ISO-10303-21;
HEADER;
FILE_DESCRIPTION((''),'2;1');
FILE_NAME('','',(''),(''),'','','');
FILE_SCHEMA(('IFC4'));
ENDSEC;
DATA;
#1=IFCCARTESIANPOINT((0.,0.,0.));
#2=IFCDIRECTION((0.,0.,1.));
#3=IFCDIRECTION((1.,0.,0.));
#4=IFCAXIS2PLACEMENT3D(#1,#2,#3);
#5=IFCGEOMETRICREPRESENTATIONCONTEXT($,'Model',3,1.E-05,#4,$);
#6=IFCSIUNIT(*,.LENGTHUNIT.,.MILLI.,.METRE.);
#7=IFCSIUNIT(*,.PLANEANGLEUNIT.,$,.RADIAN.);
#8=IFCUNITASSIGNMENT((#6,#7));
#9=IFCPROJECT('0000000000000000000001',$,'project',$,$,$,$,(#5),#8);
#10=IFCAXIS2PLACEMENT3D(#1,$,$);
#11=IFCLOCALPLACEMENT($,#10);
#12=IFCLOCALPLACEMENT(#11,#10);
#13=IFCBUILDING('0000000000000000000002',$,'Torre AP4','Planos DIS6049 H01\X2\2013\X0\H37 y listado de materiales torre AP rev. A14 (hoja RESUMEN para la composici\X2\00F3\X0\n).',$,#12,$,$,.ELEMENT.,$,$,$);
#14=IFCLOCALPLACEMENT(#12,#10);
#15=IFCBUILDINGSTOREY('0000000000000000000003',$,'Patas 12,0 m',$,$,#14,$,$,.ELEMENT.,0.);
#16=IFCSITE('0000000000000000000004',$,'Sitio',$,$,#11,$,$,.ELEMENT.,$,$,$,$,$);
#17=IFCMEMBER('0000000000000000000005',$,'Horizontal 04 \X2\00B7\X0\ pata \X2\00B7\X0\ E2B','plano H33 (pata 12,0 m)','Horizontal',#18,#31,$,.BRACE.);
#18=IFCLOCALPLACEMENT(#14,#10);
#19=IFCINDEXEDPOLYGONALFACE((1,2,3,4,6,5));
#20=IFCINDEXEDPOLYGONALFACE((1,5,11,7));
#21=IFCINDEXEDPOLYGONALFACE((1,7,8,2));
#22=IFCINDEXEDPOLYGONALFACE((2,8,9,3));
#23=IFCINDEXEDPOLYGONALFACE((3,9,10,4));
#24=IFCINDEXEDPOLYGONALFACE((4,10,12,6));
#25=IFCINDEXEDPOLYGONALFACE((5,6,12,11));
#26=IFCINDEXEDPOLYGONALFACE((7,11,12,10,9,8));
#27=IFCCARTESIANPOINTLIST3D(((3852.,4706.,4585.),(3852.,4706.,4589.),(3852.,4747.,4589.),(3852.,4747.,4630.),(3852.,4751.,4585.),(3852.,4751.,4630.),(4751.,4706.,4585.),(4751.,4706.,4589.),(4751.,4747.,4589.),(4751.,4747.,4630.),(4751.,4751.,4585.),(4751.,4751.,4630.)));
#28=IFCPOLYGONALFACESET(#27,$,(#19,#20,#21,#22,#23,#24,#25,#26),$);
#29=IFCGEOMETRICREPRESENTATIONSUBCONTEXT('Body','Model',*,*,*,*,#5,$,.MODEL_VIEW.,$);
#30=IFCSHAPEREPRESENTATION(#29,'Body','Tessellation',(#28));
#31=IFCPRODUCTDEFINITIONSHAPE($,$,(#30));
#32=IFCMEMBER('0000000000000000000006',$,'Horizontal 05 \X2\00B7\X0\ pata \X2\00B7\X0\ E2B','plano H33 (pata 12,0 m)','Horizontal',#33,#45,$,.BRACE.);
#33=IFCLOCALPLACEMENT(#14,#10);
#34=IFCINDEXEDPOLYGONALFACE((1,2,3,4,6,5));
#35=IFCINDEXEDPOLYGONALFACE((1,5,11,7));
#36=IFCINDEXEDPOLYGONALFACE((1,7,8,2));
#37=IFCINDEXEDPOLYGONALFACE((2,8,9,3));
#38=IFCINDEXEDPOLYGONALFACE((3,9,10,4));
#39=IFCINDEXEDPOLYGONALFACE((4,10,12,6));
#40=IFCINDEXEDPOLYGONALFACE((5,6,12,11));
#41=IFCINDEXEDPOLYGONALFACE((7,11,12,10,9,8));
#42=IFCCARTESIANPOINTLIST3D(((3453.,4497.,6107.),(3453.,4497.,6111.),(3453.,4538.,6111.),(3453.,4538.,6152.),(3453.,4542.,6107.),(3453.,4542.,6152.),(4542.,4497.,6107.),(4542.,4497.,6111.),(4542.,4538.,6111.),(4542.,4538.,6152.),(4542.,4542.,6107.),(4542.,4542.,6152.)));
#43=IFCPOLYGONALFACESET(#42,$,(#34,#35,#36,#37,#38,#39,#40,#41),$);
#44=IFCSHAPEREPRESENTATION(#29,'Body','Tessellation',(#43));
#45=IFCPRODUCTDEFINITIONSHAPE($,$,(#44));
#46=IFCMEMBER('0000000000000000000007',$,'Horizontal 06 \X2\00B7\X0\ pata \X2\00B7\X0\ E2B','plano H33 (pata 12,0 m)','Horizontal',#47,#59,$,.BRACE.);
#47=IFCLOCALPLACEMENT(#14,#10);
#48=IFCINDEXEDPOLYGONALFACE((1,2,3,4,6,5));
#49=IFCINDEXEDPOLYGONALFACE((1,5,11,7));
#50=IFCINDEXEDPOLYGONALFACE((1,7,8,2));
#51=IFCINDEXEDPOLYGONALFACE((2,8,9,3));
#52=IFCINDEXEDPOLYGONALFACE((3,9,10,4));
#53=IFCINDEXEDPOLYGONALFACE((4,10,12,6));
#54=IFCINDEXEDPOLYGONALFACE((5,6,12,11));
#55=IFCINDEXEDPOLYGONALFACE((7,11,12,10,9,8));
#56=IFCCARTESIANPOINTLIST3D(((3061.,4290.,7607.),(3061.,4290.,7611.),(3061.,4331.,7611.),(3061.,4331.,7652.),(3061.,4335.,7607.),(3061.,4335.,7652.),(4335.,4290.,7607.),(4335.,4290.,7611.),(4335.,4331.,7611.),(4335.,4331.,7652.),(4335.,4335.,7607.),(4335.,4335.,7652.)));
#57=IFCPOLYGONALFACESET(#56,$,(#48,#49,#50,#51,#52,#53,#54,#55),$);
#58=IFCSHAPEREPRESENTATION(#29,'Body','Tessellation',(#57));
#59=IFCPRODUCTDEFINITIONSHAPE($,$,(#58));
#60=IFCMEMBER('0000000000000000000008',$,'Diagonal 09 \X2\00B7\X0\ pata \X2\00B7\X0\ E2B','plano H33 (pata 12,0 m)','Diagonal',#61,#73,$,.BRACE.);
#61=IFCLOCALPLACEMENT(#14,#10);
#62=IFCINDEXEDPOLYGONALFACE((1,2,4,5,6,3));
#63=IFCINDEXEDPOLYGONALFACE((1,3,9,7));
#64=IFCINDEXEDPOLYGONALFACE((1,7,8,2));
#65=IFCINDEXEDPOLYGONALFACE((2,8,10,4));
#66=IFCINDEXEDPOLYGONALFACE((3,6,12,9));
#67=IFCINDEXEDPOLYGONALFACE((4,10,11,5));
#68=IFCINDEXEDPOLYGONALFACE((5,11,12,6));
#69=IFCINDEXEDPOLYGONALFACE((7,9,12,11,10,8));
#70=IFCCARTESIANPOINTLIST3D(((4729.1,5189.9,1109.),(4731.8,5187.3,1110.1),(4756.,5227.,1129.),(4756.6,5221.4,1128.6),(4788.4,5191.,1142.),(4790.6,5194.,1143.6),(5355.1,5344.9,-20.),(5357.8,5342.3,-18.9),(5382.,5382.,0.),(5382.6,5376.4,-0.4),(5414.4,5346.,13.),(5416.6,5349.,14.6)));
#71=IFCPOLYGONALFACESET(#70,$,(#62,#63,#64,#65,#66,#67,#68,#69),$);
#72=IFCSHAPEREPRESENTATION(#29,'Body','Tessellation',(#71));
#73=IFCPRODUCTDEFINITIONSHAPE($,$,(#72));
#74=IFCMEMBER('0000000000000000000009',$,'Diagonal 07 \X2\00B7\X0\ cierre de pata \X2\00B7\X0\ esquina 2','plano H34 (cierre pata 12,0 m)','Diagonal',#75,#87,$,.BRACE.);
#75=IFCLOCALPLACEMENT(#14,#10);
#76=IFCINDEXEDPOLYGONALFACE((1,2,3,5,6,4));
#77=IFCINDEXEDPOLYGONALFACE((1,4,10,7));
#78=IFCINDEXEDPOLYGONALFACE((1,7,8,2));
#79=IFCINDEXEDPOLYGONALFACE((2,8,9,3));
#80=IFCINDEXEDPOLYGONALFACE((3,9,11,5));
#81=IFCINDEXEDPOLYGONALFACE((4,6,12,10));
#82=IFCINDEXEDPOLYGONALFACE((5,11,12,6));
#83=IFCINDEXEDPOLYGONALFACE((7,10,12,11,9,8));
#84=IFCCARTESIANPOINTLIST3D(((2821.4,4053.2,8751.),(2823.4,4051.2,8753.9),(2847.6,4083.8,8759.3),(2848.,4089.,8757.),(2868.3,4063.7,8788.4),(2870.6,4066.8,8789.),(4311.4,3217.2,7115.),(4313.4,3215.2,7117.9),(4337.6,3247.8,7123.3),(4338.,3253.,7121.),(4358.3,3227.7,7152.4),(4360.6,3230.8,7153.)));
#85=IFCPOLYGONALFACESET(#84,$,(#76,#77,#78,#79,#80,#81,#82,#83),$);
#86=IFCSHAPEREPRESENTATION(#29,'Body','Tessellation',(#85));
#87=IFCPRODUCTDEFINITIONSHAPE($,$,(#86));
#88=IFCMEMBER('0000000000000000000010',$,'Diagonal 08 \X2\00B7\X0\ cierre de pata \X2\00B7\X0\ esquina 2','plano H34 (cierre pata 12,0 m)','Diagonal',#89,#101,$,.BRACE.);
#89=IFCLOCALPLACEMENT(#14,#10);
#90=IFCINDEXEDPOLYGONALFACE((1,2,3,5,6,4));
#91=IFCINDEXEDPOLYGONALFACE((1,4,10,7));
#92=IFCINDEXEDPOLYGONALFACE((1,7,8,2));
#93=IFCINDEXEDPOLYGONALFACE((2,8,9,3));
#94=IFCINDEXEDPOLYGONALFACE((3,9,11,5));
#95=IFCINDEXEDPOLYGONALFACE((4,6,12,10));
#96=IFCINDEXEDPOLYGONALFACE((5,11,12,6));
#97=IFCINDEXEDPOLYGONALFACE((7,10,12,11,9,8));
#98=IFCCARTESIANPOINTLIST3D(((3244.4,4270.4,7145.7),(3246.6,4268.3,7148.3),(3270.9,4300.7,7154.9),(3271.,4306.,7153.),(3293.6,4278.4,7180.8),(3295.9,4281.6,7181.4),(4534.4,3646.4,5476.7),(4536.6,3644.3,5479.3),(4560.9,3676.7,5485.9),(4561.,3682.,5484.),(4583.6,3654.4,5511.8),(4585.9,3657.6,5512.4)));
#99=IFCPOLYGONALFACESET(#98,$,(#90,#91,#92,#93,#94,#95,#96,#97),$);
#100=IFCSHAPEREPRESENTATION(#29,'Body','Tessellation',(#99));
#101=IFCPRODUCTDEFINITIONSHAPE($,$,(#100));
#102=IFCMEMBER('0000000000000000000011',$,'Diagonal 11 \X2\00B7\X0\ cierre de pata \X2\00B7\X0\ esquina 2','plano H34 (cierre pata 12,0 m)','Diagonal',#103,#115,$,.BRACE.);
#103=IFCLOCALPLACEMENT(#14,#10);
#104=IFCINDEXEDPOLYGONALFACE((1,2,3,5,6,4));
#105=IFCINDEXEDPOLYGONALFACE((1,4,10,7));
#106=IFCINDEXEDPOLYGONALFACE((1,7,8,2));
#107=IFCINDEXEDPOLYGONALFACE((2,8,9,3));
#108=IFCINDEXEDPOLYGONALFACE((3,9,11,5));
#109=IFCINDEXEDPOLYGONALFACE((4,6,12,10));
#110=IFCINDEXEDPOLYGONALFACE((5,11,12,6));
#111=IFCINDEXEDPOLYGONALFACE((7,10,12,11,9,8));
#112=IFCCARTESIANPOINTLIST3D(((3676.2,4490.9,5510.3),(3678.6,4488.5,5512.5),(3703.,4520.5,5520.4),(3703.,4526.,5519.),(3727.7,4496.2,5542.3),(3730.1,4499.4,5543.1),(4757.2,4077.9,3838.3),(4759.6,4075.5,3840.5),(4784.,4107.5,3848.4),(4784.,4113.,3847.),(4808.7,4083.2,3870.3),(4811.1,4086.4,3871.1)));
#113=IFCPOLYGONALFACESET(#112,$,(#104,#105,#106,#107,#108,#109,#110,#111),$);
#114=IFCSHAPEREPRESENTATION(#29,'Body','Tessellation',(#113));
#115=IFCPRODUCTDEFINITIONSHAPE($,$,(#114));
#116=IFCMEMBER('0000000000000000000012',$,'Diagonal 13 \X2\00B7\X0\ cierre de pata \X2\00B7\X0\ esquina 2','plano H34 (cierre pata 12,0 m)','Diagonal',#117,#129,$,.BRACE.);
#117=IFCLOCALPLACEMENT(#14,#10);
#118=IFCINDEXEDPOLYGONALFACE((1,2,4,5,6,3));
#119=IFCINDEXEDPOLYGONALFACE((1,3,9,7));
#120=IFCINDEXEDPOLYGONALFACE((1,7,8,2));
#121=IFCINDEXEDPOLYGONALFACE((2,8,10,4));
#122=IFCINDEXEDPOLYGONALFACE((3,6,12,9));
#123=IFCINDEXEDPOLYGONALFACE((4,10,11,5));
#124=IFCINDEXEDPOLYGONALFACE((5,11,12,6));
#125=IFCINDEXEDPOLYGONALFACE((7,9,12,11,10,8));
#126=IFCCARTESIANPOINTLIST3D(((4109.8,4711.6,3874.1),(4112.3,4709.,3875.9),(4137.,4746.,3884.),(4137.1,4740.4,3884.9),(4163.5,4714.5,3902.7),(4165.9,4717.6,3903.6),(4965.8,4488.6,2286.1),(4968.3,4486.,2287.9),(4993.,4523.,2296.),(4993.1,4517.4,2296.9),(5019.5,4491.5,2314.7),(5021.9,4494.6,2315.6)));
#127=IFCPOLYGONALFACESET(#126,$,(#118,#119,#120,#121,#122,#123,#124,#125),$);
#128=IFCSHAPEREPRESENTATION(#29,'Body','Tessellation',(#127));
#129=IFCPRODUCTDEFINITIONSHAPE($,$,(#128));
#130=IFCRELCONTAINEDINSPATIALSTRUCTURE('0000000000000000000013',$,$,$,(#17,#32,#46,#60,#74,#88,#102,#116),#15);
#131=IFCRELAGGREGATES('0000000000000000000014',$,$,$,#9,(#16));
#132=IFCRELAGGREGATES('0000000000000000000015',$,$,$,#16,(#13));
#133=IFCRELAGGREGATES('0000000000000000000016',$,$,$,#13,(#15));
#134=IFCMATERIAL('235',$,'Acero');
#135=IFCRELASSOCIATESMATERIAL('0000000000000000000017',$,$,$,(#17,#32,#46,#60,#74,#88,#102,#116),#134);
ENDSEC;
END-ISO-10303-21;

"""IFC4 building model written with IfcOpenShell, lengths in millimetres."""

from ifc_helpers import new_model, si_unit, frame, frame_2d, origin, origin_with_axes, place, context, subcontext, project, spatial, l_section, extrude, material, element, save


model = new_model("IFC4")

# Units and contexts
model_context = context("Model", 3, precision=1e-05, world=origin_with_axes())
body_context = subcontext(model_context, "Body", "Model", "MODEL_VIEW")
ifc_project = project(units=[si_unit("LENGTHUNIT", "METRE", prefix="MILLI"), si_unit("PLANEANGLEUNIT", "RADIAN")], contexts=[model_context])

# Site, building, storey
site_placement = place(None, origin())
site = spatial("IfcSite", under=ifc_project, at=site_placement, Name="Sitio", CompositionType="ELEMENT")
building_placement = place(site_placement, origin())
building = spatial("IfcBuilding", under=site, at=building_placement, Name="Torre AP4", Description="Planos DIS6049 H01–H37 y listado de materiales torre AP rev. A14 (hoja RESUMEN para la composición).", CompositionType="ELEMENT")
storey_placement = place(building_placement, origin())
storey = spatial("IfcBuildingStorey", under=building, at=storey_placement, Name="Patas 12,0 m", CompositionType="ELEMENT", Elevation=0.0)

# Members
ifc_material_1 = material(Name="235", Category="Acero")
member_1_placement = place(storey_placement, frame((4751.0, 4751.0, 4585.0), z_axis=(-1.0, 0.0, 0.0), x_axis=(0.0, -1.0, 0.0)))
element("IfcMember", 1, at=member_1_placement, inside=storey, material=ifc_material_1, Name="Horizontal 04 · pata · E2B", Description="plano H33 (pata 12,0 m)", ObjectType="Horizontal", PredefinedType="BRACE", context=body_context, shape_type="SweptSolid", body=[
    extrude(l_section(Depth=45.0, Width=45.0, Thickness=4.0, at=frame_2d((22.5, 22.5))), None, (0.0, 0.0, 1.0), 899.0),
])
member_2_placement = place(storey_placement, frame((4542.0, 4542.0, 6107.0), z_axis=(-1.0, 0.0, 0.0), x_axis=(0.0, -1.0, 0.0)))
element("IfcMember", 2, at=member_2_placement, inside=storey, material=ifc_material_1, Name="Horizontal 05 · pata · E2B", Description="plano H33 (pata 12,0 m)", ObjectType="Horizontal", PredefinedType="BRACE", context=body_context, shape_type="SweptSolid", body=[
    extrude(l_section(Depth=45.0, Width=45.0, Thickness=4.0, at=frame_2d((22.5, 22.5))), None, (0.0, 0.0, 1.0), 1089.0),
])
member_3_placement = place(storey_placement, frame((4335.0, 4335.0, 7607.0), z_axis=(-1.0, 0.0, 0.0), x_axis=(0.0, -1.0, 0.0)))
element("IfcMember", 3, at=member_3_placement, inside=storey, material=ifc_material_1, Name="Horizontal 06 · pata · E2B", Description="plano H33 (pata 12,0 m)", ObjectType="Horizontal", PredefinedType="BRACE", context=body_context, shape_type="SweptSolid", body=[
    extrude(l_section(Depth=45.0, Width=45.0, Thickness=4.0, at=frame_2d((22.5, 22.5))), None, (0.0, 0.0, 1.0), 1274.0),
])
member_4_placement = place(storey_placement, frame((5382.0, 5382.0, 0.0), z_axis=(-0.481461, -0.119212, 0.868322), x_axis=(-0.53876, -0.741182, -0.400484)))
element("IfcMember", 4, at=member_4_placement, inside=storey, material=ifc_material_1, Name="Diagonal 09 · pata · E2B", Description="plano H33 (pata 12,0 m)", ObjectType="Diagonal", PredefinedType="BRACE", context=body_context, shape_type="SweptSolid", body=[
    extrude(l_section(Depth=50.0, Width=50.0, Thickness=4.0, at=frame_2d((25.0, 25.0))), None, (0.0, 0.0, 1.0), 1300.2),
])
member_5_placement = place(storey_placement, frame((4338.0, 3253.0, 7121.0), z_axis=(-0.629894, 0.353417, 0.691615), x_axis=(-0.591591, -0.795293, -0.1324)))
element("IfcMember", 5, at=member_5_placement, inside=storey, material=ifc_material_1, Name="Diagonal 07 · cierre de pata · esquina 2", Description="plano H34 (cierre pata 12,0 m)", ObjectType="Diagonal", PredefinedType="BRACE", context=body_context, shape_type="SweptSolid", body=[
    extrude(l_section(Depth=45.0, Width=45.0, Thickness=4.0, at=frame_2d((22.5, 22.5))), None, (0.0, 0.0, 1.0), 2365.5),
])
member_6_placement = place(storey_placement, frame((4561.0, 3682.0, 5484.0), z_axis=(-0.586422, 0.283665, 0.758712), x_axis=(-0.591049, -0.790335, -0.161345)))
element("IfcMember", 6, at=member_6_placement, inside=storey, material=ifc_material_1, Name="Diagonal 08 · cierre de pata · esquina 2", Description="plano H34 (cierre pata 12,0 m)", ObjectType="Diagonal", PredefinedType="BRACE", context=body_context, shape_type="SweptSolid", body=[
    extrude(l_section(Depth=45.0, Width=45.0, Thickness=4.0, at=frame_2d((22.5, 22.5))), None, (0.0, 0.0, 1.0), 2199.8),
])
member_7_placement = place(storey_placement, frame((4784.0, 4113.0, 3847.0), z_axis=(-0.531622, 0.203108, 0.822268), x_axis=(-0.595404, -0.780084, -0.192259)))
element("IfcMember", 7, at=member_7_placement, inside=storey, material=ifc_material_1, Name="Diagonal 11 · cierre de pata · esquina 2", Description="plano H34 (cierre pata 12,0 m)", ObjectType="Diagonal", PredefinedType="BRACE", context=body_context, shape_type="SweptSolid", body=[
    extrude(l_section(Depth=45.0, Width=45.0, Thickness=4.0, at=frame_2d((22.5, 22.5))), None, (0.0, 0.0, 1.0), 2033.4),
])
member_8_placement = place(storey_placement, frame((4993.0, 4523.0, 2296.0), z_axis=(-0.470912, 0.122679, 0.873608), x_axis=(-0.605441, -0.765194, -0.218904)))
element("IfcMember", 8, at=member_8_placement, inside=storey, material=ifc_material_1, Name="Diagonal 13 · cierre de pata · esquina 2", Description="plano H34 (cierre pata 12,0 m)", ObjectType="Diagonal", PredefinedType="BRACE", context=body_context, shape_type="SweptSolid", body=[
    extrude(l_section(Depth=45.0, Width=45.0, Thickness=4.0, at=frame_2d((22.5, 22.5))), None, (0.0, 0.0, 1.0), 1817.7),
])

save(model, "model.ifc")
